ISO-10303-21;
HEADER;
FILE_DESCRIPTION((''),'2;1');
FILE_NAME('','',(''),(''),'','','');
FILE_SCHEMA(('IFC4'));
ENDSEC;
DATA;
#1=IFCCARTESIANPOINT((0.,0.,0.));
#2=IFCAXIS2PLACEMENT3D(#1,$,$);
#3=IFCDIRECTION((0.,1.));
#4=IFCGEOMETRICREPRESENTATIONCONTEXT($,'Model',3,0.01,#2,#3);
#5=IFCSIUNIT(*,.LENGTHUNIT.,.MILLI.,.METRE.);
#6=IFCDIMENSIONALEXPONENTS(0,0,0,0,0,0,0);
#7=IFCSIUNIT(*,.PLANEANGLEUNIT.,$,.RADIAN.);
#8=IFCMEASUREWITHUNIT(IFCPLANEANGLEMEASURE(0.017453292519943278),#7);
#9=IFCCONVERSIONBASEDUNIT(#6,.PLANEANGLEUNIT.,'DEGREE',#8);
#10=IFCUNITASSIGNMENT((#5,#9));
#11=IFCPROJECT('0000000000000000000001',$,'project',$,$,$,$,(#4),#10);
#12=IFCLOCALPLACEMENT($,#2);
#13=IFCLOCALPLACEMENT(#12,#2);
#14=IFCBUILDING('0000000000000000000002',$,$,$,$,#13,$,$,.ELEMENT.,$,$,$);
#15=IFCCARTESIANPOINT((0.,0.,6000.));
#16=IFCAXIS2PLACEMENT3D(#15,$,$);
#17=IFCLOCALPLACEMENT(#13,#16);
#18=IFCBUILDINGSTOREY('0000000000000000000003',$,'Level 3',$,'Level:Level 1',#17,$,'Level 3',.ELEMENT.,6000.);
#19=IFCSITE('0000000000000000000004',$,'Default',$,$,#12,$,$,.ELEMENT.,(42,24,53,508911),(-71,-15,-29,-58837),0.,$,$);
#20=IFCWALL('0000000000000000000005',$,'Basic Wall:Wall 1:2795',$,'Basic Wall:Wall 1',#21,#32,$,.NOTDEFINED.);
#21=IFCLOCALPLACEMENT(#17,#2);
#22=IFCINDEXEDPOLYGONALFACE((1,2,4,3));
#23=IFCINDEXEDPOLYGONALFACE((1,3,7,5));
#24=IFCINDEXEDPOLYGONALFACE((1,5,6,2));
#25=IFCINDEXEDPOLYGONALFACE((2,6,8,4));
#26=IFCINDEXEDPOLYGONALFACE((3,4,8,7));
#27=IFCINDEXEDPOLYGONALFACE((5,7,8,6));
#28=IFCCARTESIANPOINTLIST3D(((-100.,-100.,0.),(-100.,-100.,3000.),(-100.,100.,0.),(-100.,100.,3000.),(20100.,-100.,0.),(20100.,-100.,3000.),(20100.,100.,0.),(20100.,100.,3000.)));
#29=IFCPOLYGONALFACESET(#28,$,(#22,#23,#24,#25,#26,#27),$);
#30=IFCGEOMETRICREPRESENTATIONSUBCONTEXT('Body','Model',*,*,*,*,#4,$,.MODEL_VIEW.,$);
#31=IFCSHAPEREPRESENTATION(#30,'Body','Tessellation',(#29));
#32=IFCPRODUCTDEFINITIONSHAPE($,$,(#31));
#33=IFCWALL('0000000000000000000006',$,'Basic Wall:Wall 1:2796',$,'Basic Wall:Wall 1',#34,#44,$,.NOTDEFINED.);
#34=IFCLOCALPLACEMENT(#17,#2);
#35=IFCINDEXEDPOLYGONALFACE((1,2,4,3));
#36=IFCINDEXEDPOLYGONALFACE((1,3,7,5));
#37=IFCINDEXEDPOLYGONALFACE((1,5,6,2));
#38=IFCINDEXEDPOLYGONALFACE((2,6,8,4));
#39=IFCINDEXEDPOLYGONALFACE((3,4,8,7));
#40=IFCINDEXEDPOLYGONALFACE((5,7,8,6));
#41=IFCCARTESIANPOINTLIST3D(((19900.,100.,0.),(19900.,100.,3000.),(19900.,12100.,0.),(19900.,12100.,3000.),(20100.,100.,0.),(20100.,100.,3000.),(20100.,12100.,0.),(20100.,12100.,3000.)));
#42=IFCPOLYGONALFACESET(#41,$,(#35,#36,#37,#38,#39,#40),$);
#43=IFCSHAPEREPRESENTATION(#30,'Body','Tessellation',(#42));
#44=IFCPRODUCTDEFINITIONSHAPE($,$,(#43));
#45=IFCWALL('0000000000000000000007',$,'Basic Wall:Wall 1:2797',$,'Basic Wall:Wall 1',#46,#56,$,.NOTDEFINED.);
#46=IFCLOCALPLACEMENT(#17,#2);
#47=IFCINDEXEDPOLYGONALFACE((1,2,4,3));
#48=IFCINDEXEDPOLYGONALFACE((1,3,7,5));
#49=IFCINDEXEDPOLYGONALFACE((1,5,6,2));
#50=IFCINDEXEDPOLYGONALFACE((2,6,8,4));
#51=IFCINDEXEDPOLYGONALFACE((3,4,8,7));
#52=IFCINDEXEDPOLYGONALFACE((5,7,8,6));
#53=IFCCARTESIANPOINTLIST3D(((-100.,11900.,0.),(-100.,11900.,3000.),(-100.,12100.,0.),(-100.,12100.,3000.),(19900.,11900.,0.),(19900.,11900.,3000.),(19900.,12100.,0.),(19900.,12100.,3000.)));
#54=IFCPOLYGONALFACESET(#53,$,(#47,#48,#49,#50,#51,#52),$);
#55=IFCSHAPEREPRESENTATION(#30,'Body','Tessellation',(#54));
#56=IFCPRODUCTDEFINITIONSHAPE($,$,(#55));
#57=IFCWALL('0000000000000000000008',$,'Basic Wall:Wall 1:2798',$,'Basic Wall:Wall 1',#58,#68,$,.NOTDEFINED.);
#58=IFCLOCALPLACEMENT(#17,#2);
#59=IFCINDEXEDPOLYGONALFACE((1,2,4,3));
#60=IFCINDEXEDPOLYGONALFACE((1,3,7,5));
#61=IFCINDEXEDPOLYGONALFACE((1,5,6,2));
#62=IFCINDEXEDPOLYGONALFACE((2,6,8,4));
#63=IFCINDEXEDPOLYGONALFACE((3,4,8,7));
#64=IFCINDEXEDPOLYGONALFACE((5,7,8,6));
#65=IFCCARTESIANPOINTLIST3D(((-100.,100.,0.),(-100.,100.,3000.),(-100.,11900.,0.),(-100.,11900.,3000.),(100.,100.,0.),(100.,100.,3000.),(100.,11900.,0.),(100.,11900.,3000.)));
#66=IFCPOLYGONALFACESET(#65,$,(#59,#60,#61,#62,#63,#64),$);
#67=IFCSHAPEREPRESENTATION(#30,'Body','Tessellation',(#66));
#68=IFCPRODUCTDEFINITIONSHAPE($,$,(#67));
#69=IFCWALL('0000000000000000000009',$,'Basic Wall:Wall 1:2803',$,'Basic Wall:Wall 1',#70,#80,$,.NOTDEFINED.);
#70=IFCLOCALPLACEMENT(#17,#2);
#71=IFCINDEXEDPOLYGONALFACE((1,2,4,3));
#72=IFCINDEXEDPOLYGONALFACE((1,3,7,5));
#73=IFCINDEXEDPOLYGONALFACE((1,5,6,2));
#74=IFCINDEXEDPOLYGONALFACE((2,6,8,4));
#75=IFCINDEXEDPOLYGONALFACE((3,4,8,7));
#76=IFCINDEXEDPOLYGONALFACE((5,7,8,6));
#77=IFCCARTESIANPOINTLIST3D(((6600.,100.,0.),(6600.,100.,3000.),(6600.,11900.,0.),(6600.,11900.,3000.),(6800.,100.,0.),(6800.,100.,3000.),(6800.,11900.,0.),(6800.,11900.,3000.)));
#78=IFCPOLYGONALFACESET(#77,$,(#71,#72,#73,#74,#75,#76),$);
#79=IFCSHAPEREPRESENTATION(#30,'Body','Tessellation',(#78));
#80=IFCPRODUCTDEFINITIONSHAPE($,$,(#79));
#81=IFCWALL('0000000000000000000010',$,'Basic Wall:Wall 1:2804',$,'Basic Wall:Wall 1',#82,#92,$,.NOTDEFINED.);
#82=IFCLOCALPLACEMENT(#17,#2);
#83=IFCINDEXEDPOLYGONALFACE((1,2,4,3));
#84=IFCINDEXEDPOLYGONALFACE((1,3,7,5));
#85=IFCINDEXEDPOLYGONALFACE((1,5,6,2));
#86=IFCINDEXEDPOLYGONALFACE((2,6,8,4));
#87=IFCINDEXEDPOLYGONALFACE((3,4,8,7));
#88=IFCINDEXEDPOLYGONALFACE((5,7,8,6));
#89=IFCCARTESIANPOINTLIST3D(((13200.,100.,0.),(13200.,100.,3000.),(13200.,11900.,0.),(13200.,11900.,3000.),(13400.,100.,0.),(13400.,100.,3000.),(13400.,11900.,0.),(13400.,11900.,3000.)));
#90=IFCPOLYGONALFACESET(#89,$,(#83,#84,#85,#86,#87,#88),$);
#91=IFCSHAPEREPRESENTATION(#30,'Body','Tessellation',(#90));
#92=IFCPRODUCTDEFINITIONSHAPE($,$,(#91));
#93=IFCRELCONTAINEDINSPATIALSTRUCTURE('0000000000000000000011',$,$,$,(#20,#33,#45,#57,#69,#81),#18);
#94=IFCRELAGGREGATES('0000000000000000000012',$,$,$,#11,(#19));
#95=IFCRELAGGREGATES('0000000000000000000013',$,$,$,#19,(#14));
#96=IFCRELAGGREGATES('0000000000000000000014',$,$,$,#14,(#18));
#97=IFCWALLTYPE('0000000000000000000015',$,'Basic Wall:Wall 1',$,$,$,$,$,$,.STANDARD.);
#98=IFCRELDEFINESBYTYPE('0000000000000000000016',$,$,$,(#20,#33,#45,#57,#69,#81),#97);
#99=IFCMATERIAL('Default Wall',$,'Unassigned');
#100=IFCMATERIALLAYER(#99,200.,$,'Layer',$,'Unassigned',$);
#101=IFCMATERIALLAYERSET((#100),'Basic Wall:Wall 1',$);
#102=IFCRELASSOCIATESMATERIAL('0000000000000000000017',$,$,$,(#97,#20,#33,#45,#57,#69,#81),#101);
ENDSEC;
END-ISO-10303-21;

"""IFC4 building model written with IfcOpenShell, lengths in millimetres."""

from ifc_helpers import new_model, entity, si_unit, converted_unit, direction, frame, frame_2d, origin, place, context, subcontext, project, spatial, rectangle, extrude, material, layer, layer_set, layer_usage, type_object, element, save


model = new_model("IFC4")

# Units and contexts
model_context = context("Model", 3, precision=0.01, world=origin(), true_north=direction((0.0, 1.0)))
body_context = subcontext(model_context, "Body", "Model", "MODEL_VIEW")
ifc_project = project(units=[si_unit("LENGTHUNIT", "METRE", prefix="MILLI"), converted_unit("PLANEANGLEUNIT", "DEGREE", entity("IfcPlaneAngleMeasure", 0.017453292519943278), si_unit("PLANEANGLEUNIT", "RADIAN"), dimensions=[0, 0, 0, 0, 0, 0, 0])], contexts=[model_context])

# Site, building, storey
site_placement = place(None, origin())
site = spatial("IfcSite", under=ifc_project, at=site_placement, Name="Default", CompositionType="ELEMENT", RefLatitude=(42, 24, 53, 508911), RefLongitude=(-71, -15, -29, -58837), RefElevation=0.0)
building_placement = place(site_placement, origin())
building = spatial("IfcBuilding", under=site, at=building_placement, CompositionType="ELEMENT")
storey_placement = place(building_placement, frame((0.0, 0.0, 6000.0)))
storey = spatial("IfcBuildingStorey", under=building, at=storey_placement, Name="Level 3", ObjectType="Level:Level 1", LongName="Level 3", CompositionType="ELEMENT", Elevation=6000.0)

# Walls
ifc_material_1 = material(Name="Default Wall", Category="Unassigned")
ifc_layer_1 = layer(ifc_material_1, 200.0, Name="Layer", Category="Unassigned")
ifc_layer_set_1 = layer_set([ifc_layer_1], Name="Basic Wall:Wall 1")
ifc_layer_usage_1 = layer_usage(ifc_layer_set_1, "AXIS2", "NEGATIVE", 100.0)
wall_type = type_object("IfcWallType", Name="Basic Wall:Wall 1", PredefinedType="STANDARD", material=ifc_layer_set_1)
wall_1_placement = place(storey_placement, frame((-100.0, 0.0, 0.0)))
element("IfcWall", 1, at=wall_1_placement, inside=storey, type_object=wall_type, material=ifc_layer_usage_1, Name="Basic Wall:Wall 1:2795", ObjectType="Basic Wall:Wall 1", PredefinedType="NOTDEFINED", context=body_context, shape_type="SweptSolid", body=[
    extrude(rectangle(XDim=20200.0, YDim=200.0, at=frame_2d((10100.0, 0.0), x_axis=(-1.0, 0.0))), origin(), (0.0, 0.0, 1.0), 3000.0),
])
ifc_layer_usage_2 = layer_usage(ifc_layer_set_1, "AXIS2", "NEGATIVE", 100.0)
wall_2_placement = place(storey_placement, frame((20000.0, 100.0, 0.0), z_axis=(0.0, 0.0, 1.0), x_axis=(0.0, 1.0, 0.0)))
element("IfcWall", 2, at=wall_2_placement, inside=storey, type_object=wall_type, material=ifc_layer_usage_2, Name="Basic Wall:Wall 1:2796", ObjectType="Basic Wall:Wall 1", PredefinedType="NOTDEFINED", context=body_context, shape_type="SweptSolid", body=[
    extrude(rectangle(XDim=12000.0, YDim=200.0, at=frame_2d((6000.0, 0.0), x_axis=(-1.0, 0.0))), origin(), (0.0, 0.0, 1.0), 3000.0),
])
ifc_layer_usage_3 = layer_usage(ifc_layer_set_1, "AXIS2", "NEGATIVE", 100.0)
wall_3_placement = place(storey_placement, frame((19900.0, 12000.0, 0.0), z_axis=(0.0, 0.0, 1.0), x_axis=(-1.0, 0.0, 0.0)))
element("IfcWall", 3, at=wall_3_placement, inside=storey, type_object=wall_type, material=ifc_layer_usage_3, Name="Basic Wall:Wall 1:2797", ObjectType="Basic Wall:Wall 1", PredefinedType="NOTDEFINED", context=body_context, shape_type="SweptSolid", body=[
    extrude(rectangle(XDim=20000.0, YDim=200.0, at=frame_2d((10000.0, 0.0), x_axis=(-1.0, 0.0))), origin(), (0.0, 0.0, 1.0), 3000.0),
])
ifc_layer_usage_4 = layer_usage(ifc_layer_set_1, "AXIS2", "NEGATIVE", 100.0)
wall_4_placement = place(storey_placement, frame((0.0, 11900.0, 0.0), z_axis=(0.0, 0.0, 1.0), x_axis=(0.0, -1.0, 0.0)))
element("IfcWall", 4, at=wall_4_placement, inside=storey, type_object=wall_type, material=ifc_layer_usage_4, Name="Basic Wall:Wall 1:2798", ObjectType="Basic Wall:Wall 1", PredefinedType="NOTDEFINED", context=body_context, shape_type="SweptSolid", body=[
    extrude(rectangle(XDim=11800.0, YDim=200.0, at=frame_2d((5900.0, 0.0), x_axis=(-1.0, 0.0))), origin(), (0.0, 0.0, 1.0), 3000.0),
])
ifc_layer_usage_5 = layer_usage(ifc_layer_set_1, "AXIS2", "NEGATIVE", 100.0)
wall_5_placement = place(storey_placement, frame((6700.0, 100.0, 0.0), z_axis=(0.0, 0.0, 1.0), x_axis=(0.0, 1.0, 0.0)))
element("IfcWall", 5, at=wall_5_placement, inside=storey, type_object=wall_type, material=ifc_layer_usage_5, Name="Basic Wall:Wall 1:2803", ObjectType="Basic Wall:Wall 1", PredefinedType="NOTDEFINED", context=body_context, shape_type="SweptSolid", body=[
    extrude(rectangle(XDim=11800.0, YDim=200.0, at=frame_2d((5900.0, 0.0), x_axis=(-1.0, 0.0))), origin(), (0.0, 0.0, 1.0), 3000.0),
])
ifc_layer_usage_6 = layer_usage(ifc_layer_set_1, "AXIS2", "NEGATIVE", 100.0)
wall_6_placement = place(storey_placement, frame((13300.0, 100.0, 0.0), z_axis=(0.0, 0.0, 1.0), x_axis=(0.0, 1.0, 0.0)))
element("IfcWall", 6, at=wall_6_placement, inside=storey, type_object=wall_type, material=ifc_layer_usage_6, Name="Basic Wall:Wall 1:2804", ObjectType="Basic Wall:Wall 1", PredefinedType="NOTDEFINED", context=body_context, shape_type="SweptSolid", body=[
    extrude(rectangle(XDim=11800.0, YDim=200.0, at=frame_2d((5900.0, 0.0), x_axis=(-1.0, 0.0))), origin(), (0.0, 0.0, 1.0), 3000.0),
])

save(model, "model.ifc")
